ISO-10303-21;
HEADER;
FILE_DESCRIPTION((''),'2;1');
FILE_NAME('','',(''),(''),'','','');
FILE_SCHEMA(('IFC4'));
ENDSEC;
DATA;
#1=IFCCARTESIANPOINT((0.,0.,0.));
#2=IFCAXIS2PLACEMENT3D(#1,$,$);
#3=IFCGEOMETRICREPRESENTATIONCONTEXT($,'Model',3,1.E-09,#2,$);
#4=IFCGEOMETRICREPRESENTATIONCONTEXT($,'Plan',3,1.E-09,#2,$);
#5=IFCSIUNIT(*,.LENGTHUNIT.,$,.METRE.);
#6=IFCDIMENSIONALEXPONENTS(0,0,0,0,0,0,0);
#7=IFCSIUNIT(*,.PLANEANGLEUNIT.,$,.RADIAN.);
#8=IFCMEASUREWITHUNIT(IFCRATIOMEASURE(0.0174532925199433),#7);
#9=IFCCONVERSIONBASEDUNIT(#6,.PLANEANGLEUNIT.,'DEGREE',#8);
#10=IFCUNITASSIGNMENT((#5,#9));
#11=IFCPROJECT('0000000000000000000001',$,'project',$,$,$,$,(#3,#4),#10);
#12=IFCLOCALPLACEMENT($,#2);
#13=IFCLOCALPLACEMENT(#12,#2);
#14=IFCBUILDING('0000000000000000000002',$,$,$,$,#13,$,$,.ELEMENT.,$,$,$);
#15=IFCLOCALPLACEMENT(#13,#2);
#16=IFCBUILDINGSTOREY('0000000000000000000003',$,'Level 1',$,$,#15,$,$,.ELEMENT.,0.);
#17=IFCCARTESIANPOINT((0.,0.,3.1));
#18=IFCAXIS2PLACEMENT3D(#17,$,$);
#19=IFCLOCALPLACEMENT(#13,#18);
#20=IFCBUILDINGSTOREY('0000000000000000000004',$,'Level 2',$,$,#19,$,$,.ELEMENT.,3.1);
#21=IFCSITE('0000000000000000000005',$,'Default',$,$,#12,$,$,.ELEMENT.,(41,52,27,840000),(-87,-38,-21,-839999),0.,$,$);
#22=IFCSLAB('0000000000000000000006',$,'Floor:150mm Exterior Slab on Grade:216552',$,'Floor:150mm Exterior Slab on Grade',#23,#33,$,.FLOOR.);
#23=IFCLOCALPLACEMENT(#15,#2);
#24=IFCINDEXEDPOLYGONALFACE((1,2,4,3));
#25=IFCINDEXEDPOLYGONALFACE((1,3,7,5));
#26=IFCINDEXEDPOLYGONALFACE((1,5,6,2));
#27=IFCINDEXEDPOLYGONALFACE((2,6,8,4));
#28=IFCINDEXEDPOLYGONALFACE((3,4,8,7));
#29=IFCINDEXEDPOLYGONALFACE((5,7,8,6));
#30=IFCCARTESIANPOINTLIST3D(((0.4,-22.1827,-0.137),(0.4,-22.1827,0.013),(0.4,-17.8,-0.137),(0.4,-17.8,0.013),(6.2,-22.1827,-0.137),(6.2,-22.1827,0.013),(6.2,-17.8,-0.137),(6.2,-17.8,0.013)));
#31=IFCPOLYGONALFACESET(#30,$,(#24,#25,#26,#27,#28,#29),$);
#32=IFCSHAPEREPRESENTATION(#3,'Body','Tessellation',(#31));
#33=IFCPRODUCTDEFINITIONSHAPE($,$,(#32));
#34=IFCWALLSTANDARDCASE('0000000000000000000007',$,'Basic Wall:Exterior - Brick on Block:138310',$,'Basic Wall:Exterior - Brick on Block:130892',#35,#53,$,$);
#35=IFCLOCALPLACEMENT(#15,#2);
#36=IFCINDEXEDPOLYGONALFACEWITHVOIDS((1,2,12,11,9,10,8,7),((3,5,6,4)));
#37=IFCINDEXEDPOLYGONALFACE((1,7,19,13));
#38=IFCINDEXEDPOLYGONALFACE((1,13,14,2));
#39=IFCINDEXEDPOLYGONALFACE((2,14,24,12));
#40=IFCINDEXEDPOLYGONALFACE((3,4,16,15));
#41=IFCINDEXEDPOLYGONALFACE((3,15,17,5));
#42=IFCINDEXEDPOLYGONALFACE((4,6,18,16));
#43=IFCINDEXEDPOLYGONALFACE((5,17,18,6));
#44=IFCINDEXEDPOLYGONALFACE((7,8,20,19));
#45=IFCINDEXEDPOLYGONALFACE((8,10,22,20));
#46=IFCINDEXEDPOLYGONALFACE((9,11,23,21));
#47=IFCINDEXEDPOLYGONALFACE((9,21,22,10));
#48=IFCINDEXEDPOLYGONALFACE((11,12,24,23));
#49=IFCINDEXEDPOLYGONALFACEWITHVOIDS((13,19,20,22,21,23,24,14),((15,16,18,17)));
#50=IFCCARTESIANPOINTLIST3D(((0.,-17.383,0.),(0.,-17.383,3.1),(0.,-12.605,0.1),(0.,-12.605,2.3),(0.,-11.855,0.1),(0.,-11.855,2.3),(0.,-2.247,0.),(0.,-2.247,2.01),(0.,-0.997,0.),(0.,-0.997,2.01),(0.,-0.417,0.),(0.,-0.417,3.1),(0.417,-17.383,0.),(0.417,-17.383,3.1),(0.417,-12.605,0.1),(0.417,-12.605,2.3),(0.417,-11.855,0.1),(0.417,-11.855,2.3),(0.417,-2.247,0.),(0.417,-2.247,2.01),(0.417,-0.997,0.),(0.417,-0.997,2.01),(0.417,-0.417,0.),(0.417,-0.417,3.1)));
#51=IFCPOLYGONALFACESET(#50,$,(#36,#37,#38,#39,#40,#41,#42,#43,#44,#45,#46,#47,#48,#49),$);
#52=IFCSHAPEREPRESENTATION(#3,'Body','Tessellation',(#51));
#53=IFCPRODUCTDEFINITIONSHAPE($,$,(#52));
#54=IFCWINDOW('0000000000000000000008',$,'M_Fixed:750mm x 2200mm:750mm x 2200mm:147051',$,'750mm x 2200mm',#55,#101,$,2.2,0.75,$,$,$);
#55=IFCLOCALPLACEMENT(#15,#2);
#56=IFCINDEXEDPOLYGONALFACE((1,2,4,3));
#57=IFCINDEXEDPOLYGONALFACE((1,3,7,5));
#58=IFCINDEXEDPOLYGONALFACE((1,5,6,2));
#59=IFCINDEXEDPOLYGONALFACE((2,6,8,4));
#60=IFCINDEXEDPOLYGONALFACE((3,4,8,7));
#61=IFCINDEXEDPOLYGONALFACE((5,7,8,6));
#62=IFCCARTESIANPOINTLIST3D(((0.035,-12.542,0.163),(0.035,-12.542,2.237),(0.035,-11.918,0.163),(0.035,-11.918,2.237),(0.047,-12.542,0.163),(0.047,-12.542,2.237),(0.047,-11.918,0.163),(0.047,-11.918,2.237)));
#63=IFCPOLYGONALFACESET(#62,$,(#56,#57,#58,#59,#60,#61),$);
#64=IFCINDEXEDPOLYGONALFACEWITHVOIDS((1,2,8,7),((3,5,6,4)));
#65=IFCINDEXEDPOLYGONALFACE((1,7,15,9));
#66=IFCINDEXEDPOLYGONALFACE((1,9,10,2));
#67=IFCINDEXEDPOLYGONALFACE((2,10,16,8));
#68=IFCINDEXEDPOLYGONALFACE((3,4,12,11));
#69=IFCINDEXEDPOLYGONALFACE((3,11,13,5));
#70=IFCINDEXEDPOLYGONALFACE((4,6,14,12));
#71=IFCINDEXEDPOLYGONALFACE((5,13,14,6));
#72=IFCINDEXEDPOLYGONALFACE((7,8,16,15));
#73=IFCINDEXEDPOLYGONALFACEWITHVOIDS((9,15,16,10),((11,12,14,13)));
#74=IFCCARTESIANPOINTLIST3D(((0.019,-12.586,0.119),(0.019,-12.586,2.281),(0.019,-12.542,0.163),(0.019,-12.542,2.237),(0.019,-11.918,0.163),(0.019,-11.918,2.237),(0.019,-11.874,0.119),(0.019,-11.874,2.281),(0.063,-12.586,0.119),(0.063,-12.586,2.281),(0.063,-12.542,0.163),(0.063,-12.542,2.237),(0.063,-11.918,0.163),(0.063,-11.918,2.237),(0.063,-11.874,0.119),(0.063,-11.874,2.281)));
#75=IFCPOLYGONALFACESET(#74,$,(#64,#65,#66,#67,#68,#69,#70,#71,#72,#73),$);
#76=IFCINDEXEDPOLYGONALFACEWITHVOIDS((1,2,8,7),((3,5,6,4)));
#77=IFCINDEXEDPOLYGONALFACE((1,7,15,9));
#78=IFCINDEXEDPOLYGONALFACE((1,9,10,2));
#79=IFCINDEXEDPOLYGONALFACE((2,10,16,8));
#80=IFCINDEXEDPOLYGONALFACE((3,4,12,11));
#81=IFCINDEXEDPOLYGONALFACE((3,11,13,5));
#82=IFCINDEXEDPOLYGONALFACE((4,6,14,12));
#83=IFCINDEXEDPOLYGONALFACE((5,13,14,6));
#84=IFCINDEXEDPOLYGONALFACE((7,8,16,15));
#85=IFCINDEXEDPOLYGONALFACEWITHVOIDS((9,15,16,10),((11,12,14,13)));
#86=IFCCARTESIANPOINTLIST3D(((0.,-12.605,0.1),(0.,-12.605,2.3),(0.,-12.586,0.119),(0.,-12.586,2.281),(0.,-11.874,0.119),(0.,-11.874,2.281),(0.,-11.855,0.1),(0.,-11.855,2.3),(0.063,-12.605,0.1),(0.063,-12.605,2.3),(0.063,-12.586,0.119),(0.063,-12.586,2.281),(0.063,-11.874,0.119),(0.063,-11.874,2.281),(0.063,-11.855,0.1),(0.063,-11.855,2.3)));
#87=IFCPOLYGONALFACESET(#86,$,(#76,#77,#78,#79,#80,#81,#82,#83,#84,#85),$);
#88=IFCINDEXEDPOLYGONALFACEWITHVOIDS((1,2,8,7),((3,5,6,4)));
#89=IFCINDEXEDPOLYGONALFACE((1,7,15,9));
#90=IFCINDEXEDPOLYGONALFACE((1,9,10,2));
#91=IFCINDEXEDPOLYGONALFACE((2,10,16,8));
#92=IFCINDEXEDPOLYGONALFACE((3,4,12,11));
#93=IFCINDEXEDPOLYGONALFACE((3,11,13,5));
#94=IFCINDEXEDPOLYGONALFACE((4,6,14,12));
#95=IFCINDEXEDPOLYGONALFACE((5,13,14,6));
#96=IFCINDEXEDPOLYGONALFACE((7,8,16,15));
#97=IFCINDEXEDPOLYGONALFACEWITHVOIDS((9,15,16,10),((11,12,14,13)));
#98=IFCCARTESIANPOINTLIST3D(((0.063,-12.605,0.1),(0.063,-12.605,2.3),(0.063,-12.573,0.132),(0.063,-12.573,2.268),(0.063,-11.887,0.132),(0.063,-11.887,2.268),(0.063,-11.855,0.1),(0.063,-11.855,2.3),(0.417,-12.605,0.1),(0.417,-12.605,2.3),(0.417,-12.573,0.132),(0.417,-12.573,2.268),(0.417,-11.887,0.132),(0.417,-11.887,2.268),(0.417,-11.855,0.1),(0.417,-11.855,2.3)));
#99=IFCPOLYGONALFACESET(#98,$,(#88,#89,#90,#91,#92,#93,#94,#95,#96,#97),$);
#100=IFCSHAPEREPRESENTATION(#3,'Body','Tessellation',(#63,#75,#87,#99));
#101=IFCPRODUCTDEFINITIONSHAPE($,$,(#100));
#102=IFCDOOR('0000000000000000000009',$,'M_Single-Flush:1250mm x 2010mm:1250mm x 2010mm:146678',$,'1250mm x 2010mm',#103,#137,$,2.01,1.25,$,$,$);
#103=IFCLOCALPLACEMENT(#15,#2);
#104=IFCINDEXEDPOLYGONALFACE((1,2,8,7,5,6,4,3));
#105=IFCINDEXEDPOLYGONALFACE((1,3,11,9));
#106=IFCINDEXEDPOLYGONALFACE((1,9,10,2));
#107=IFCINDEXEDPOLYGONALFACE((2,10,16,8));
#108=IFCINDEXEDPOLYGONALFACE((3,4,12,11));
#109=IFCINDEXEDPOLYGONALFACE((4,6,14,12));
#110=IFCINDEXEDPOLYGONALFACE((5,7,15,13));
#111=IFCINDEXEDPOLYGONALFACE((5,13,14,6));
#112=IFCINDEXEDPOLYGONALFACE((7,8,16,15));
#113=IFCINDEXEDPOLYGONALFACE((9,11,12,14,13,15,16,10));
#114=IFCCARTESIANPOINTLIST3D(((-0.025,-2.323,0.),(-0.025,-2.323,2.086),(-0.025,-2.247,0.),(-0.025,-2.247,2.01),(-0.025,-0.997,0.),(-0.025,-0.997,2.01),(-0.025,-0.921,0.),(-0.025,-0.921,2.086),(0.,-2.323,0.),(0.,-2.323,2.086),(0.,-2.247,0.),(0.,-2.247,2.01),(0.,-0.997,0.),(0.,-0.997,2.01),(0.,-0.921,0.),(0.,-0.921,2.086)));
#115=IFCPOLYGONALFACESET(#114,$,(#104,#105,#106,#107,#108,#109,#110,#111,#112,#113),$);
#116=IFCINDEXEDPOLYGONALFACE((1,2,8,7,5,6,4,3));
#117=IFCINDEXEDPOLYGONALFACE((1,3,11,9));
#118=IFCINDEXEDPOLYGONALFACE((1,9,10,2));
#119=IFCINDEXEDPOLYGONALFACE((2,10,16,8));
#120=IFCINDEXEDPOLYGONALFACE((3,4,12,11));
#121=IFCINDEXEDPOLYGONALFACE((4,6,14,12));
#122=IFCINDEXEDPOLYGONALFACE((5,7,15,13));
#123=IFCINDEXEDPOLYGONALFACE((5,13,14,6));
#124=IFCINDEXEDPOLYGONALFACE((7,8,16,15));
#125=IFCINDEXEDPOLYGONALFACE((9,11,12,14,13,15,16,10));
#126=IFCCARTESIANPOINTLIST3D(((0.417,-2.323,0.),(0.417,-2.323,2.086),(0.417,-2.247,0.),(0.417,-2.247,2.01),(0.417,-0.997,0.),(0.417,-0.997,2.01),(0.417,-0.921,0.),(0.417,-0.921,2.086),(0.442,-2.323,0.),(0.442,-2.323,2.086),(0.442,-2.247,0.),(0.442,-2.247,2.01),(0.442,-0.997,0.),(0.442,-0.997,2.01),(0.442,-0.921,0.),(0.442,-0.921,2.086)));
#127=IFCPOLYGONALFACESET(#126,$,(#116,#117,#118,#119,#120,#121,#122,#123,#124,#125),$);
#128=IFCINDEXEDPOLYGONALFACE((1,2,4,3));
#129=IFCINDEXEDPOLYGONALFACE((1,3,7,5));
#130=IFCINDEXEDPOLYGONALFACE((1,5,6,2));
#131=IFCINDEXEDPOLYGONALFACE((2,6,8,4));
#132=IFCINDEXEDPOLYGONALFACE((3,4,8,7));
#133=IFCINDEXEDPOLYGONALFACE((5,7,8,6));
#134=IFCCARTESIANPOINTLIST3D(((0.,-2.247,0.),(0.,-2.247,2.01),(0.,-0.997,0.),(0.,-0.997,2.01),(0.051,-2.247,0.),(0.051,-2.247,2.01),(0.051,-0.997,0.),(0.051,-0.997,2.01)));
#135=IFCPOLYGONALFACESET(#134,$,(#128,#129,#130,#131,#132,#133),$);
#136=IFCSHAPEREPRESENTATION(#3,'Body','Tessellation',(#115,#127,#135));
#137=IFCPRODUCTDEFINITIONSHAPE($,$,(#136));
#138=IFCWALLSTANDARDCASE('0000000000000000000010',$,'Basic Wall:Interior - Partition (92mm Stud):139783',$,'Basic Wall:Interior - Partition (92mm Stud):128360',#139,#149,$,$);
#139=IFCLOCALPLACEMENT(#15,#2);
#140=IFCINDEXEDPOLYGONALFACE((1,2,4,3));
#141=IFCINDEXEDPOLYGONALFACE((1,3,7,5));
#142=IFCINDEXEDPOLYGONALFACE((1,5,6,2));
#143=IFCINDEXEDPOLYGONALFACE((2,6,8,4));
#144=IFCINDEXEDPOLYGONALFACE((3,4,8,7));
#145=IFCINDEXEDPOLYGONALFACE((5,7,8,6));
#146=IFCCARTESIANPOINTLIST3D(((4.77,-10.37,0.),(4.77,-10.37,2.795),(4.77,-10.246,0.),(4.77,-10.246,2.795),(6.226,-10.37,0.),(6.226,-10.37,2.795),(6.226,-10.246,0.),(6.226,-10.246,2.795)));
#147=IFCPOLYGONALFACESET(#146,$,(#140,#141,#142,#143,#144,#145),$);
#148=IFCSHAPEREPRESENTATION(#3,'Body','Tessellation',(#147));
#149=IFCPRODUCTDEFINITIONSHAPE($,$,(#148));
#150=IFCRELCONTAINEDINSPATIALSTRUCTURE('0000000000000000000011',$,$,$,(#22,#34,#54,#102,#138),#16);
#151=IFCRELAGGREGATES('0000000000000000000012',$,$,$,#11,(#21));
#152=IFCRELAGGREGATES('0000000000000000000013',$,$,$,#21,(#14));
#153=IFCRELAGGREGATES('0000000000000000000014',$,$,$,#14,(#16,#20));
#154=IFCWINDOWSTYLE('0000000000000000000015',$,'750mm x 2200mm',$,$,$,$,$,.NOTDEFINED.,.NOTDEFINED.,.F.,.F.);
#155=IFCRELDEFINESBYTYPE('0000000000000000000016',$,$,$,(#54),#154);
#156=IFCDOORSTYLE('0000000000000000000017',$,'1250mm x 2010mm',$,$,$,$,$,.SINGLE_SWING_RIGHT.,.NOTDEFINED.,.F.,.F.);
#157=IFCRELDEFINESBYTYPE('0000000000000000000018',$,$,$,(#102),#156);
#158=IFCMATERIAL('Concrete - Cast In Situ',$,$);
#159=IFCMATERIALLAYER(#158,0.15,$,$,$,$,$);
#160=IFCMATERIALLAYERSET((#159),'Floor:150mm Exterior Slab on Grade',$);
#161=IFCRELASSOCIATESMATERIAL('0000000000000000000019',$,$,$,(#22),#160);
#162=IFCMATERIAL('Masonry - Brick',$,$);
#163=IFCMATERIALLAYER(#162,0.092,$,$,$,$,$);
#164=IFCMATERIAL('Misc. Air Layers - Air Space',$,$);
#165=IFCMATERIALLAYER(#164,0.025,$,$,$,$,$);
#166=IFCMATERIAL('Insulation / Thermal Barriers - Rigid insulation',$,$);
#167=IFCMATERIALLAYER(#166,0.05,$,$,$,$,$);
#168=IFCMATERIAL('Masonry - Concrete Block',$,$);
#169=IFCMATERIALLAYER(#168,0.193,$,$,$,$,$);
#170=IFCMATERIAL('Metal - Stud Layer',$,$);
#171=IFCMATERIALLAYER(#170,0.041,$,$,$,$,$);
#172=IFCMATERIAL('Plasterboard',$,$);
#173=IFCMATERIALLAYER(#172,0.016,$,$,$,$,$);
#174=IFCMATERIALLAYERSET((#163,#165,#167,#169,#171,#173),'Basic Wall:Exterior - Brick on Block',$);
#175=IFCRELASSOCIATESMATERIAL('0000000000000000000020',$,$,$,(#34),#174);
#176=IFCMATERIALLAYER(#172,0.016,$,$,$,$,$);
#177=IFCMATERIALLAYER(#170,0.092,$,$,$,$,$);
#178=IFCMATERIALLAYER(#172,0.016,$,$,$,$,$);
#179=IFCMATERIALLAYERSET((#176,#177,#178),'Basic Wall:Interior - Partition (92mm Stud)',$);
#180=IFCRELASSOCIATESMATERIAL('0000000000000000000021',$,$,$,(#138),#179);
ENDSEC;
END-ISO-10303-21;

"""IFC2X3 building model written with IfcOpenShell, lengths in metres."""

from ifc_helpers import new_model, entity, si_unit, converted_unit, frame, frame_2d, origin, origin_2d_with_axis, place, context, project, spatial, polyline, rectangle, outline, extrude, source, transform, mapped, material, layer, layer_set, layer_usage, type_object, type_shapes, element, fill, save


model = new_model("IFC2X3")

# Units and contexts
model_context = context("Model", 3, precision=1e-09, world=origin())
plan_context = context("Plan", 3, precision=1e-09, world=origin())
ifc_project = project(units=[si_unit("LENGTHUNIT", "METRE"), converted_unit("PLANEANGLEUNIT", "DEGREE", entity("IfcRatioMeasure", 0.0174532925199433), si_unit("PLANEANGLEUNIT", "RADIAN"), dimensions=[0, 0, 0, 0, 0, 0, 0])], contexts=[model_context, plan_context])

# Site, building, storey
site_placement = place(None, origin())
site = spatial("IfcSite", under=ifc_project, at=site_placement, Name="Default", CompositionType="ELEMENT", RefLatitude=(41, 52, 27, 840000), RefLongitude=(-87, -38, -21, -839999), RefElevation=0.0)
building_placement = place(site_placement, origin())
building = spatial("IfcBuilding", under=site, at=building_placement, CompositionType="ELEMENT")
storey_1_placement = place(building_placement, origin())
storey_1 = spatial("IfcBuildingStorey", under=building, at=storey_1_placement, Name="Level 1", CompositionType="ELEMENT", Elevation=0.0)

# Slab
ifc_material_1 = material(Name="Concrete - Cast In Situ")
ifc_layer_1 = layer(ifc_material_1, 0.15)
ifc_layer_set_1 = layer_set([ifc_layer_1], Name="Floor:150mm Exterior Slab on Grade")
ifc_layer_usage_1 = layer_usage(ifc_layer_set_1, "AXIS3", "POSITIVE", 0.0)
slab_1_placement = place(storey_1_placement, frame((0.4, -22.1827, -0.137)))
element("IfcSlab", 1, at=slab_1_placement, inside=storey_1, material=ifc_layer_usage_1, Name="Floor:150mm Exterior Slab on Grade:216552", ObjectType="Floor:150mm Exterior Slab on Grade", PredefinedType="FLOOR", context=model_context, shape_type="SweptSolid", body=[
    extrude(rectangle(XDim=5.8, YDim=4.3827, at=origin_2d_with_axis()), frame((2.9, 2.1914, 0.15), z_axis=(0.0, 0.0, -1.0), x_axis=(-1.0, 0.0, 0.0)), (0.0, 0.0, 1.0), 0.15),
])

# Wall, openings, window, door
ifc_material_2 = material(Name="Masonry - Brick")
ifc_layer_2 = layer(ifc_material_2, 0.092)
ifc_material_3 = material(Name="Misc. Air Layers - Air Space")
ifc_layer_3 = layer(ifc_material_3, 0.025)
ifc_material_4 = material(Name="Insulation / Thermal Barriers - Rigid insulation")
ifc_layer_4 = layer(ifc_material_4, 0.05)
ifc_material_5 = material(Name="Masonry - Concrete Block")
ifc_layer_5 = layer(ifc_material_5, 0.193)
ifc_material_6 = material(Name="Metal - Stud Layer")
ifc_layer_6 = layer(ifc_material_6, 0.041)
ifc_material_7 = material(Name="Plasterboard")
ifc_layer_7 = layer(ifc_material_7, 0.016)
ifc_layer_set_2 = layer_set([ifc_layer_2, ifc_layer_3, ifc_layer_4, ifc_layer_5, ifc_layer_6, ifc_layer_7], Name="Basic Wall:Exterior - Brick on Block")
ifc_layer_usage_2 = layer_usage(ifc_layer_set_2, "AXIS2", "NEGATIVE", 0.2085)
wall_1_placement = place(storey_1_placement, frame((0.2085, -17.383, 0.0), z_axis=(0.0, 0.0, 1.0), x_axis=(0.0, 1.0, 0.0)))
wall_1 = element("IfcWallStandardCase", 2, at=wall_1_placement, inside=storey_1, material=ifc_layer_usage_2, Name="Basic Wall:Exterior - Brick on Block:138310", ObjectType="Basic Wall:Exterior - Brick on Block:130892", context=model_context, shape_type="SweptSolid", body=[
    extrude(rectangle(XDim=16.966, YDim=0.417, at=frame_2d((8.483, 0.0), x_axis=(-1.0, 0.0))), origin(), (0.0, 0.0, 1.0), 3.1),
])
opening_1_placement = place(wall_1_placement, frame((15.136, -0.2085, 0.0)))
opening_1 = element("IfcOpeningElement", 3, at=opening_1_placement, cuts=wall_1, ObjectType="Opening", context=model_context, shape_type="SweptSolid", body=[
    extrude(rectangle(XDim=1.25, YDim=2.01, at=frame_2d((1.005, 0.625), x_axis=(0.0, 1.0))), frame((0.0, 0.0, 0.0), z_axis=(0.0, 1.0, 0.0), x_axis=(0.0, 0.0, 1.0)), (0.0, 0.0, 1.0), 0.417),
])
opening_2_placement = place(wall_1_placement, frame((4.778, -0.2085, 0.1)))
opening_2 = element("IfcOpeningElement", 4, at=opening_2_placement, cuts=wall_1, ObjectType="Opening", context=model_context, shape_type="SweptSolid", body=[
    extrude(rectangle(XDim=2.2, YDim=0.75, at=frame_2d((1.1, 0.375), x_axis=(1.0, 0.0))), frame((0.0, 0.0, 0.0), z_axis=(0.0, 1.0, 0.0), x_axis=(0.0, 0.0, 1.0)), (0.0, 0.0, 1.0), 0.417),
])
window_style_1 = type_object("IfcWindowStyle", Name="750mm x 2200mm", ConstructionType="NOTDEFINED", OperationType="NOTDEFINED", ParameterTakesPrecedence=False, Sizeable=False)
shared_shape_1 = source(origin(), model_context, "Body", "SweptSolid", [
    extrude(rectangle(XDim=0.012, YDim=0.624, at=origin_2d_with_axis()), frame((0.375, 0.376, 0.063), z_axis=(0.0, 0.0, 1.0), x_axis=(0.0, -1.0, 0.0)), (0.0, 0.0, 1.0), 2.074),
    extrude(outline(polyline([(-0.356, -1.081), (0.356, -1.081), (0.356, 1.081), (-0.356, 1.081), (-0.356, -1.081)]), holes=[polyline([(-0.312, -1.037), (-0.312, 1.037), (0.312, 1.037), (0.312, -1.037), (-0.312, -1.037)])]), frame((0.375, 0.354, 1.1), z_axis=(0.0, 1.0, 0.0), x_axis=(1.0, 0.0, 0.0)), (0.0, 0.0, 1.0), 0.044),
    extrude(outline(polyline([(-0.375, -1.1), (0.375, -1.1), (0.375, 1.1), (-0.375, 1.1), (-0.375, -1.1)]), holes=[polyline([(-0.356, -1.081), (-0.356, 1.081), (0.356, 1.081), (0.356, -1.081), (-0.356, -1.081)])]), frame((0.375, 0.354, 1.1), z_axis=(0.0, 1.0, 0.0), x_axis=(1.0, 0.0, 0.0)), (0.0, 0.0, 1.0), 0.063),
    extrude(outline(polyline([(-0.375, -1.1), (0.375, -1.1), (0.375, 1.1), (-0.375, 1.1), (-0.375, -1.1)]), holes=[polyline([(-0.343, -1.068), (-0.343, 1.068), (0.343, 1.068), (0.343, -1.068), (-0.343, -1.068)])]), frame((0.375, 0.0, 1.1), z_axis=(0.0, 1.0, 0.0), x_axis=(1.0, 0.0, 0.0)), (0.0, 0.0, 1.0), 0.354),
])
type_shapes(window_style_1, [shared_shape_1])
window_1_placement = place(opening_2_placement, origin())
window_1 = element("IfcWindow", 5, at=window_1_placement, inside=storey_1, type_object=window_style_1, Name="M_Fixed:750mm x 2200mm:750mm x 2200mm:147051", ObjectType="750mm x 2200mm", OverallHeight=2.2, OverallWidth=0.75, context=model_context, shape_type="MappedRepresentation", body=[
    mapped(shared_shape_1, transform((0.0, 0.0, 0.0), scale=1.0)),
])
fill(opening_2, window_1)
door_style_1 = type_object("IfcDoorStyle", Name="1250mm x 2010mm", ConstructionType="NOTDEFINED", OperationType="SINGLE_SWING_RIGHT", ParameterTakesPrecedence=False, Sizeable=False)
shared_shape_2 = source(origin(), model_context, "Body", "SweptSolid", [
    extrude(outline(polyline([(-0.701, -1.062), (0.701, -1.062), (0.701, 1.024), (0.625, 1.024), (0.625, -0.986), (-0.625, -0.986), (-0.625, 1.024), (-0.701, 1.024), (-0.701, -1.062)])), frame((0.625, 0.417, 1.024), z_axis=(0.0, 1.0, 0.0), x_axis=(1.0, 0.0, 0.0)), (0.0, 0.0, 1.0), 0.025),
    extrude(outline(polyline([(-1.062, -0.701), (1.024, -0.701), (1.024, -0.625), (-0.986, -0.625), (-0.986, 0.625), (1.024, 0.625), (1.024, 0.701), (-1.062, 0.701), (-1.062, -0.701)])), frame((0.625, -0.025, 1.024), z_axis=(0.0, 1.0, 0.0), x_axis=(0.0, 0.0, -1.0)), (0.0, 0.0, 1.0), 0.025),
    extrude(rectangle(XDim=0.051, YDim=1.25, at=origin_2d_with_axis()), frame((0.625, 0.3915, 0.0), z_axis=(0.0, 0.0, 1.0), x_axis=(0.0, 1.0, 0.0)), (0.0, 0.0, 1.0), 2.01),
])
type_shapes(door_style_1, [shared_shape_2])
door_1_placement = place(opening_1_placement, origin())
door_1 = element("IfcDoor", 6, at=door_1_placement, inside=storey_1, type_object=door_style_1, Name="M_Single-Flush:1250mm x 2010mm:1250mm x 2010mm:146678", ObjectType="1250mm x 2010mm", OverallHeight=2.01, OverallWidth=1.25, context=model_context, shape_type="MappedRepresentation", body=[
    mapped(shared_shape_2, transform((0.0, 0.0, 0.0), scale=1.0)),
])
fill(opening_1, door_1)

# Wall
ifc_layer_8 = layer(ifc_material_7, 0.016)
ifc_layer_9 = layer(ifc_material_6, 0.092)
ifc_layer_10 = layer(ifc_material_7, 0.016)
ifc_layer_set_3 = layer_set([ifc_layer_8, ifc_layer_9, ifc_layer_10], Name="Basic Wall:Interior - Partition (92mm Stud)")
ifc_layer_usage_3 = layer_usage(ifc_layer_set_3, "AXIS2", "NEGATIVE", 0.062)
wall_2_placement = place(storey_1_placement, frame((4.77, -10.308, 0.0)))
element("IfcWallStandardCase", 7, at=wall_2_placement, inside=storey_1, material=ifc_layer_usage_3, Name="Basic Wall:Interior - Partition (92mm Stud):139783", ObjectType="Basic Wall:Interior - Partition (92mm Stud):128360", context=model_context, shape_type="SweptSolid", body=[
    extrude(rectangle(XDim=1.456, YDim=0.124, at=frame_2d((0.728, 0.0), x_axis=(-1.0, 0.0))), origin(), (0.0, 0.0, 1.0), 2.795),
])

# Shared definitions
storey_2_placement = place(building_placement, frame((0.0, 0.0, 3.1)))
storey_2 = spatial("IfcBuildingStorey", under=building, at=storey_2_placement, Name="Level 2", CompositionType="ELEMENT", Elevation=3.1)

save(model, "model.ifc")
